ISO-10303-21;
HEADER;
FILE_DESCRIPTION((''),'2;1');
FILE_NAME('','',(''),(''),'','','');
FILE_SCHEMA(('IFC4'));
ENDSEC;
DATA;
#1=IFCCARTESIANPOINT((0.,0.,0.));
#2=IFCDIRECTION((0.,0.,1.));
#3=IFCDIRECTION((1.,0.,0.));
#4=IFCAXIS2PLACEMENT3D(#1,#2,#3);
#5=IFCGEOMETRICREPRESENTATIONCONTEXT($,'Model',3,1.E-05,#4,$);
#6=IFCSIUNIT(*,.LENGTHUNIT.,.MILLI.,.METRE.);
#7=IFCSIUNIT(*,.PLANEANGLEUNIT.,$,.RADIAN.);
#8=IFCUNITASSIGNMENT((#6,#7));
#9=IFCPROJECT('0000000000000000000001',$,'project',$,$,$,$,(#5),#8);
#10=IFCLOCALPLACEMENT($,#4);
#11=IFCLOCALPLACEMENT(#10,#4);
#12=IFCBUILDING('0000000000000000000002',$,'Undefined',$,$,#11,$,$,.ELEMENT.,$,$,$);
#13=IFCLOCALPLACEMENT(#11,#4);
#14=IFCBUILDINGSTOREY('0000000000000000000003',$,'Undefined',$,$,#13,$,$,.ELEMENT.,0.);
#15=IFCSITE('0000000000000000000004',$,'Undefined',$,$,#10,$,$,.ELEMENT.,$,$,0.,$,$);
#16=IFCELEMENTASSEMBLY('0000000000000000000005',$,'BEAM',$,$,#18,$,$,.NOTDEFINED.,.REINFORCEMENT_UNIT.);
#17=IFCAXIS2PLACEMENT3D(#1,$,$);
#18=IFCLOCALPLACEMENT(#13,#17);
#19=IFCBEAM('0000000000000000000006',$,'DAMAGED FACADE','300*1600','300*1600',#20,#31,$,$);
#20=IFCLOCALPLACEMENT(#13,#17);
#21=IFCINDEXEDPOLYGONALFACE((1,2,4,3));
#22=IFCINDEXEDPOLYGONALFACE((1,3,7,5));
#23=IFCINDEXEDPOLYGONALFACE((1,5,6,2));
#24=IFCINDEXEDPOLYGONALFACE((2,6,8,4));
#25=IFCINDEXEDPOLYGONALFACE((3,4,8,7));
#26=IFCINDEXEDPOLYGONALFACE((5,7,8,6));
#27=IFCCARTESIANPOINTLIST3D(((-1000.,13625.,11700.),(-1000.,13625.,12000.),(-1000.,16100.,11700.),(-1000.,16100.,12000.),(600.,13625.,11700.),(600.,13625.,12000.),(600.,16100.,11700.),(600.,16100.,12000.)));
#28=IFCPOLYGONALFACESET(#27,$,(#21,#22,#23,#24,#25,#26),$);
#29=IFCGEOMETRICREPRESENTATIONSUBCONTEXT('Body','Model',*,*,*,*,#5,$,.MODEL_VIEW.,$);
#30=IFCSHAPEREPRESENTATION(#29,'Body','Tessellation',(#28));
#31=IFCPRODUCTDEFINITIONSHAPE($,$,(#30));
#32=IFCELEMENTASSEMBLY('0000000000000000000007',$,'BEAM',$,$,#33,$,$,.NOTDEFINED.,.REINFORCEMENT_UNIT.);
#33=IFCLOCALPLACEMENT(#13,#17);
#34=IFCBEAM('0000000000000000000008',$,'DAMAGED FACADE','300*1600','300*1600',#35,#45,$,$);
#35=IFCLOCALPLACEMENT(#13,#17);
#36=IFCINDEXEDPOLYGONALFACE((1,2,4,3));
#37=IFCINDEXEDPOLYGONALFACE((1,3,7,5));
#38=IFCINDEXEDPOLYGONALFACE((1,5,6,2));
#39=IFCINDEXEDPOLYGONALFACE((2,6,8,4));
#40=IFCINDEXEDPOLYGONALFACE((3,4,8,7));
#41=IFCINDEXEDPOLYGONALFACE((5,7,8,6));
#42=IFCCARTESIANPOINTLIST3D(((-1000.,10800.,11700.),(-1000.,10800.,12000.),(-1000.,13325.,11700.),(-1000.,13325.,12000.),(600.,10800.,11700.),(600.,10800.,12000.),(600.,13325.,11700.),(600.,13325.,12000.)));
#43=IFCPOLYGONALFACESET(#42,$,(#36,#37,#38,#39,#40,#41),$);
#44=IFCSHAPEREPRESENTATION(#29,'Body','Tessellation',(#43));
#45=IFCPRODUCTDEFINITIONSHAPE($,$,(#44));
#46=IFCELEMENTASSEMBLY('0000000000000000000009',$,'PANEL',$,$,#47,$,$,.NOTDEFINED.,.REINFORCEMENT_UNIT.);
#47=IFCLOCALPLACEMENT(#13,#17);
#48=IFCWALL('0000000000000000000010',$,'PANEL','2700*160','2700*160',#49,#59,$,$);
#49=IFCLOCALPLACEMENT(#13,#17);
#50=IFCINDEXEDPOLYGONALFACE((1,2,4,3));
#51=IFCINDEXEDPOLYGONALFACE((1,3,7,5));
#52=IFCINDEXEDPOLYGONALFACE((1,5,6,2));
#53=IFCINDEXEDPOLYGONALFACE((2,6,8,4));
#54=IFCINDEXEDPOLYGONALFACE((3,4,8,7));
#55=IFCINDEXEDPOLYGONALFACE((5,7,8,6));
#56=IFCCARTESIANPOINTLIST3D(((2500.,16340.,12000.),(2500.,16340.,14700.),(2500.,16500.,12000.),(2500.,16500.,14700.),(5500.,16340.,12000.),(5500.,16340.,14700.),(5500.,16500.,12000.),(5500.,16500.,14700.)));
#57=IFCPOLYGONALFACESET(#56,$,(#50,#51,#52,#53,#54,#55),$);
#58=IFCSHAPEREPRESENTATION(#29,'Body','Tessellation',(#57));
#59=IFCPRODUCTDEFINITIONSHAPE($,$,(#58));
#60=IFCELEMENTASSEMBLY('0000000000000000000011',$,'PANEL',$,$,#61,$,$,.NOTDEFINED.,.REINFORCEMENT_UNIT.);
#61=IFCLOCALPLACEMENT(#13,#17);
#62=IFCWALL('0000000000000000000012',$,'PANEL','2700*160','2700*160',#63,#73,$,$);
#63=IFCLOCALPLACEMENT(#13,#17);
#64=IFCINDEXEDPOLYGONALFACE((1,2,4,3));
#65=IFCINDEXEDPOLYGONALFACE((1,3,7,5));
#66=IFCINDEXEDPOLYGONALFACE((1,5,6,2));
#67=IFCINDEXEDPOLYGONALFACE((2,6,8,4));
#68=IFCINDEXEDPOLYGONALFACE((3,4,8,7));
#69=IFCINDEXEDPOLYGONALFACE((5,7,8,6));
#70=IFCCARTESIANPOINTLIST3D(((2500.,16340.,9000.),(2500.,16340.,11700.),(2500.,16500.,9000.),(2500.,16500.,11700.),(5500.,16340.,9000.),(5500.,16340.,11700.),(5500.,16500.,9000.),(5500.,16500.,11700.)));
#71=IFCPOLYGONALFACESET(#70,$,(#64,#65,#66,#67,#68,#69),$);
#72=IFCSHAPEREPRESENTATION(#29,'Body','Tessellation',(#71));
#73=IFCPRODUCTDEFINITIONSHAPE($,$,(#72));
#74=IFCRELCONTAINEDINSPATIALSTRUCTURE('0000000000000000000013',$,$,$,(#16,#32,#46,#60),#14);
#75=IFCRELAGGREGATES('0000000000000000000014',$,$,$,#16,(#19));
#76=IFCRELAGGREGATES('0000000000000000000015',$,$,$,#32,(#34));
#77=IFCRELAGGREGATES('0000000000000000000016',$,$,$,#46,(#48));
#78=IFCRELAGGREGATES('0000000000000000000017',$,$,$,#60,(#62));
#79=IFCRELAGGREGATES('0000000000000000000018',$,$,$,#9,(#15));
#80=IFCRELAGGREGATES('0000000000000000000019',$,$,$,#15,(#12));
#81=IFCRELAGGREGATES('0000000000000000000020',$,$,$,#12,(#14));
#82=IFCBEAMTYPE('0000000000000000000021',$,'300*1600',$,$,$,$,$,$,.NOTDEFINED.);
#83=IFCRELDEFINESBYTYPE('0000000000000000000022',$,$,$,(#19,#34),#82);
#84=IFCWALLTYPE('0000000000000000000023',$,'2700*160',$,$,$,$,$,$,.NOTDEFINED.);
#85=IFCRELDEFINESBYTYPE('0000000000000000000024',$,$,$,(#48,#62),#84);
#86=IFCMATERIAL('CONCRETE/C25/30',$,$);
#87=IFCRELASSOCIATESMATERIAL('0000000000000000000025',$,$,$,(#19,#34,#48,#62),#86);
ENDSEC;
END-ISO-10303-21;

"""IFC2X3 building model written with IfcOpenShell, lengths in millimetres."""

from ifc_helpers import new_model, si_unit, frame, frame_2d, origin_with_axes, origin_2d_with_axis, place, context, subcontext, project, spatial, rectangle, extrude, material, type_object, element, aggregate, save


model = new_model("IFC2X3")

# Units and contexts
model_context = context("Model", 3, precision=1e-05, world=origin_with_axes())
body_context = subcontext(model_context, "Body", "Model", "MODEL_VIEW")
ifc_project = project(units=[si_unit("LENGTHUNIT", "METRE", prefix="MILLI"), si_unit("PLANEANGLEUNIT", "RADIAN")], contexts=[model_context])

# Site, building, storey
site_placement = place(None, origin_with_axes())
site = spatial("IfcSite", under=ifc_project, at=site_placement, Name="Undefined", CompositionType="ELEMENT", RefElevation=0.0)
building_placement = place(site_placement, origin_with_axes())
building = spatial("IfcBuilding", under=site, at=building_placement, Name="Undefined", CompositionType="ELEMENT")
storey_placement = place(building_placement, origin_with_axes())
storey = spatial("IfcBuildingStorey", under=building, at=storey_placement, Name="Undefined", CompositionType="ELEMENT", Elevation=0.0)

# Shared definitions
ifc_material = material(Name="CONCRETE/C25/30")

# Element assemblies, beams
beam_type_1 = type_object("IfcBeamType", Name="300*1600", PredefinedType="NOTDEFINED")
assembly_1_placement = place(storey_placement, origin_with_axes())
assembly_1 = element("IfcElementAssembly", 1, at=assembly_1_placement, inside=storey, Name="BEAM", AssemblyPlace="NOTDEFINED", PredefinedType="REINFORCEMENT_UNIT")
beam_1_placement = place(assembly_1_placement, frame((-200.0, 13625.0, 11850.0), z_axis=(0.0, 0.0, 1.0), x_axis=(0.0, 1.0, 0.0)))
beam_1 = element("IfcBeam", 2, at=beam_1_placement, type_object=beam_type_1, material=ifc_material, Name="DAMAGED FACADE", Description="300*1600", ObjectType="300*1600", context=body_context, shape_type="SweptSolid", body=[
    extrude(rectangle(XDim=1600.0, YDim=300.0, at=origin_2d_with_axis()), frame((2475.0, 0.0, 0.0), z_axis=(-1.0, 0.0, 0.0), x_axis=(0.0, -1.0, 0.0)), (0.0, 0.0, 1.0), 2475.0),
])
aggregate(assembly_1, [beam_1])
assembly_2_placement = place(storey_placement, origin_with_axes())
assembly_2 = element("IfcElementAssembly", 3, at=assembly_2_placement, inside=storey, Name="BEAM", AssemblyPlace="NOTDEFINED", PredefinedType="REINFORCEMENT_UNIT")
beam_2_placement = place(assembly_2_placement, frame((-200.0, 13325.0, 11850.0), z_axis=(0.0, 0.0, 1.0), x_axis=(0.0, -1.0, 0.0)))
beam_2 = element("IfcBeam", 4, at=beam_2_placement, type_object=beam_type_1, material=ifc_material, Name="DAMAGED FACADE", Description="300*1600", ObjectType="300*1600", context=body_context, shape_type="SweptSolid", body=[
    extrude(rectangle(XDim=1600.0, YDim=300.0, at=origin_2d_with_axis()), frame((2525.0, 0.0, 0.0), z_axis=(-1.0, 0.0, 0.0), x_axis=(0.0, -1.0, 0.0)), (0.0, 0.0, 1.0), 2525.0),
])
aggregate(assembly_2, [beam_2])

# Element assemblies, walls
assembly_3_placement = place(storey_placement, origin_with_axes())
assembly_3 = element("IfcElementAssembly", 5, at=assembly_3_placement, inside=storey, Name="PANEL", AssemblyPlace="NOTDEFINED", PredefinedType="REINFORCEMENT_UNIT")
wall_type_1 = type_object("IfcWallType", Name="2700*160", PredefinedType="NOTDEFINED")
wall_1_placement = place(assembly_3_placement, frame((2500.0, 16420.0, 12000.0), z_axis=(0.0, 0.0, 1.0), x_axis=(1.0, 0.0, 0.0)))
wall_1 = element("IfcWall", 6, at=wall_1_placement, type_object=wall_type_1, material=ifc_material, Name="PANEL", Description="2700*160", ObjectType="2700*160", context=body_context, shape_type="SweptSolid", body=[
    extrude(rectangle(XDim=3000.0, YDim=160.0, at=frame_2d((0.0, 1500.0), x_axis=(0.0, -1.0))), frame((0.0, 0.0, 0.0), z_axis=(0.0, 0.0, 1.0), x_axis=(0.0, -1.0, 0.0)), (0.0, 0.0, 1.0), 2700.0),
])
aggregate(assembly_3, [wall_1])
assembly_4_placement = place(storey_placement, origin_with_axes())
assembly_4 = element("IfcElementAssembly", 7, at=assembly_4_placement, inside=storey, Name="PANEL", AssemblyPlace="NOTDEFINED", PredefinedType="REINFORCEMENT_UNIT")
wall_2_placement = place(assembly_4_placement, frame((2500.0, 16420.0, 9000.0), z_axis=(0.0, 0.0, 1.0), x_axis=(1.0, 0.0, 0.0)))
wall_2 = element("IfcWall", 8, at=wall_2_placement, type_object=wall_type_1, material=ifc_material, Name="PANEL", Description="2700*160", ObjectType="2700*160", context=body_context, shape_type="SweptSolid", body=[
    extrude(rectangle(XDim=3000.0, YDim=160.0, at=frame_2d((0.0, 1500.0), x_axis=(0.0, -1.0))), frame((0.0, 0.0, 0.0), z_axis=(0.0, 0.0, 1.0), x_axis=(0.0, -1.0, 0.0)), (0.0, 0.0, 1.0), 2700.0),
])
aggregate(assembly_4, [wall_2])

save(model, "model.ifc")
